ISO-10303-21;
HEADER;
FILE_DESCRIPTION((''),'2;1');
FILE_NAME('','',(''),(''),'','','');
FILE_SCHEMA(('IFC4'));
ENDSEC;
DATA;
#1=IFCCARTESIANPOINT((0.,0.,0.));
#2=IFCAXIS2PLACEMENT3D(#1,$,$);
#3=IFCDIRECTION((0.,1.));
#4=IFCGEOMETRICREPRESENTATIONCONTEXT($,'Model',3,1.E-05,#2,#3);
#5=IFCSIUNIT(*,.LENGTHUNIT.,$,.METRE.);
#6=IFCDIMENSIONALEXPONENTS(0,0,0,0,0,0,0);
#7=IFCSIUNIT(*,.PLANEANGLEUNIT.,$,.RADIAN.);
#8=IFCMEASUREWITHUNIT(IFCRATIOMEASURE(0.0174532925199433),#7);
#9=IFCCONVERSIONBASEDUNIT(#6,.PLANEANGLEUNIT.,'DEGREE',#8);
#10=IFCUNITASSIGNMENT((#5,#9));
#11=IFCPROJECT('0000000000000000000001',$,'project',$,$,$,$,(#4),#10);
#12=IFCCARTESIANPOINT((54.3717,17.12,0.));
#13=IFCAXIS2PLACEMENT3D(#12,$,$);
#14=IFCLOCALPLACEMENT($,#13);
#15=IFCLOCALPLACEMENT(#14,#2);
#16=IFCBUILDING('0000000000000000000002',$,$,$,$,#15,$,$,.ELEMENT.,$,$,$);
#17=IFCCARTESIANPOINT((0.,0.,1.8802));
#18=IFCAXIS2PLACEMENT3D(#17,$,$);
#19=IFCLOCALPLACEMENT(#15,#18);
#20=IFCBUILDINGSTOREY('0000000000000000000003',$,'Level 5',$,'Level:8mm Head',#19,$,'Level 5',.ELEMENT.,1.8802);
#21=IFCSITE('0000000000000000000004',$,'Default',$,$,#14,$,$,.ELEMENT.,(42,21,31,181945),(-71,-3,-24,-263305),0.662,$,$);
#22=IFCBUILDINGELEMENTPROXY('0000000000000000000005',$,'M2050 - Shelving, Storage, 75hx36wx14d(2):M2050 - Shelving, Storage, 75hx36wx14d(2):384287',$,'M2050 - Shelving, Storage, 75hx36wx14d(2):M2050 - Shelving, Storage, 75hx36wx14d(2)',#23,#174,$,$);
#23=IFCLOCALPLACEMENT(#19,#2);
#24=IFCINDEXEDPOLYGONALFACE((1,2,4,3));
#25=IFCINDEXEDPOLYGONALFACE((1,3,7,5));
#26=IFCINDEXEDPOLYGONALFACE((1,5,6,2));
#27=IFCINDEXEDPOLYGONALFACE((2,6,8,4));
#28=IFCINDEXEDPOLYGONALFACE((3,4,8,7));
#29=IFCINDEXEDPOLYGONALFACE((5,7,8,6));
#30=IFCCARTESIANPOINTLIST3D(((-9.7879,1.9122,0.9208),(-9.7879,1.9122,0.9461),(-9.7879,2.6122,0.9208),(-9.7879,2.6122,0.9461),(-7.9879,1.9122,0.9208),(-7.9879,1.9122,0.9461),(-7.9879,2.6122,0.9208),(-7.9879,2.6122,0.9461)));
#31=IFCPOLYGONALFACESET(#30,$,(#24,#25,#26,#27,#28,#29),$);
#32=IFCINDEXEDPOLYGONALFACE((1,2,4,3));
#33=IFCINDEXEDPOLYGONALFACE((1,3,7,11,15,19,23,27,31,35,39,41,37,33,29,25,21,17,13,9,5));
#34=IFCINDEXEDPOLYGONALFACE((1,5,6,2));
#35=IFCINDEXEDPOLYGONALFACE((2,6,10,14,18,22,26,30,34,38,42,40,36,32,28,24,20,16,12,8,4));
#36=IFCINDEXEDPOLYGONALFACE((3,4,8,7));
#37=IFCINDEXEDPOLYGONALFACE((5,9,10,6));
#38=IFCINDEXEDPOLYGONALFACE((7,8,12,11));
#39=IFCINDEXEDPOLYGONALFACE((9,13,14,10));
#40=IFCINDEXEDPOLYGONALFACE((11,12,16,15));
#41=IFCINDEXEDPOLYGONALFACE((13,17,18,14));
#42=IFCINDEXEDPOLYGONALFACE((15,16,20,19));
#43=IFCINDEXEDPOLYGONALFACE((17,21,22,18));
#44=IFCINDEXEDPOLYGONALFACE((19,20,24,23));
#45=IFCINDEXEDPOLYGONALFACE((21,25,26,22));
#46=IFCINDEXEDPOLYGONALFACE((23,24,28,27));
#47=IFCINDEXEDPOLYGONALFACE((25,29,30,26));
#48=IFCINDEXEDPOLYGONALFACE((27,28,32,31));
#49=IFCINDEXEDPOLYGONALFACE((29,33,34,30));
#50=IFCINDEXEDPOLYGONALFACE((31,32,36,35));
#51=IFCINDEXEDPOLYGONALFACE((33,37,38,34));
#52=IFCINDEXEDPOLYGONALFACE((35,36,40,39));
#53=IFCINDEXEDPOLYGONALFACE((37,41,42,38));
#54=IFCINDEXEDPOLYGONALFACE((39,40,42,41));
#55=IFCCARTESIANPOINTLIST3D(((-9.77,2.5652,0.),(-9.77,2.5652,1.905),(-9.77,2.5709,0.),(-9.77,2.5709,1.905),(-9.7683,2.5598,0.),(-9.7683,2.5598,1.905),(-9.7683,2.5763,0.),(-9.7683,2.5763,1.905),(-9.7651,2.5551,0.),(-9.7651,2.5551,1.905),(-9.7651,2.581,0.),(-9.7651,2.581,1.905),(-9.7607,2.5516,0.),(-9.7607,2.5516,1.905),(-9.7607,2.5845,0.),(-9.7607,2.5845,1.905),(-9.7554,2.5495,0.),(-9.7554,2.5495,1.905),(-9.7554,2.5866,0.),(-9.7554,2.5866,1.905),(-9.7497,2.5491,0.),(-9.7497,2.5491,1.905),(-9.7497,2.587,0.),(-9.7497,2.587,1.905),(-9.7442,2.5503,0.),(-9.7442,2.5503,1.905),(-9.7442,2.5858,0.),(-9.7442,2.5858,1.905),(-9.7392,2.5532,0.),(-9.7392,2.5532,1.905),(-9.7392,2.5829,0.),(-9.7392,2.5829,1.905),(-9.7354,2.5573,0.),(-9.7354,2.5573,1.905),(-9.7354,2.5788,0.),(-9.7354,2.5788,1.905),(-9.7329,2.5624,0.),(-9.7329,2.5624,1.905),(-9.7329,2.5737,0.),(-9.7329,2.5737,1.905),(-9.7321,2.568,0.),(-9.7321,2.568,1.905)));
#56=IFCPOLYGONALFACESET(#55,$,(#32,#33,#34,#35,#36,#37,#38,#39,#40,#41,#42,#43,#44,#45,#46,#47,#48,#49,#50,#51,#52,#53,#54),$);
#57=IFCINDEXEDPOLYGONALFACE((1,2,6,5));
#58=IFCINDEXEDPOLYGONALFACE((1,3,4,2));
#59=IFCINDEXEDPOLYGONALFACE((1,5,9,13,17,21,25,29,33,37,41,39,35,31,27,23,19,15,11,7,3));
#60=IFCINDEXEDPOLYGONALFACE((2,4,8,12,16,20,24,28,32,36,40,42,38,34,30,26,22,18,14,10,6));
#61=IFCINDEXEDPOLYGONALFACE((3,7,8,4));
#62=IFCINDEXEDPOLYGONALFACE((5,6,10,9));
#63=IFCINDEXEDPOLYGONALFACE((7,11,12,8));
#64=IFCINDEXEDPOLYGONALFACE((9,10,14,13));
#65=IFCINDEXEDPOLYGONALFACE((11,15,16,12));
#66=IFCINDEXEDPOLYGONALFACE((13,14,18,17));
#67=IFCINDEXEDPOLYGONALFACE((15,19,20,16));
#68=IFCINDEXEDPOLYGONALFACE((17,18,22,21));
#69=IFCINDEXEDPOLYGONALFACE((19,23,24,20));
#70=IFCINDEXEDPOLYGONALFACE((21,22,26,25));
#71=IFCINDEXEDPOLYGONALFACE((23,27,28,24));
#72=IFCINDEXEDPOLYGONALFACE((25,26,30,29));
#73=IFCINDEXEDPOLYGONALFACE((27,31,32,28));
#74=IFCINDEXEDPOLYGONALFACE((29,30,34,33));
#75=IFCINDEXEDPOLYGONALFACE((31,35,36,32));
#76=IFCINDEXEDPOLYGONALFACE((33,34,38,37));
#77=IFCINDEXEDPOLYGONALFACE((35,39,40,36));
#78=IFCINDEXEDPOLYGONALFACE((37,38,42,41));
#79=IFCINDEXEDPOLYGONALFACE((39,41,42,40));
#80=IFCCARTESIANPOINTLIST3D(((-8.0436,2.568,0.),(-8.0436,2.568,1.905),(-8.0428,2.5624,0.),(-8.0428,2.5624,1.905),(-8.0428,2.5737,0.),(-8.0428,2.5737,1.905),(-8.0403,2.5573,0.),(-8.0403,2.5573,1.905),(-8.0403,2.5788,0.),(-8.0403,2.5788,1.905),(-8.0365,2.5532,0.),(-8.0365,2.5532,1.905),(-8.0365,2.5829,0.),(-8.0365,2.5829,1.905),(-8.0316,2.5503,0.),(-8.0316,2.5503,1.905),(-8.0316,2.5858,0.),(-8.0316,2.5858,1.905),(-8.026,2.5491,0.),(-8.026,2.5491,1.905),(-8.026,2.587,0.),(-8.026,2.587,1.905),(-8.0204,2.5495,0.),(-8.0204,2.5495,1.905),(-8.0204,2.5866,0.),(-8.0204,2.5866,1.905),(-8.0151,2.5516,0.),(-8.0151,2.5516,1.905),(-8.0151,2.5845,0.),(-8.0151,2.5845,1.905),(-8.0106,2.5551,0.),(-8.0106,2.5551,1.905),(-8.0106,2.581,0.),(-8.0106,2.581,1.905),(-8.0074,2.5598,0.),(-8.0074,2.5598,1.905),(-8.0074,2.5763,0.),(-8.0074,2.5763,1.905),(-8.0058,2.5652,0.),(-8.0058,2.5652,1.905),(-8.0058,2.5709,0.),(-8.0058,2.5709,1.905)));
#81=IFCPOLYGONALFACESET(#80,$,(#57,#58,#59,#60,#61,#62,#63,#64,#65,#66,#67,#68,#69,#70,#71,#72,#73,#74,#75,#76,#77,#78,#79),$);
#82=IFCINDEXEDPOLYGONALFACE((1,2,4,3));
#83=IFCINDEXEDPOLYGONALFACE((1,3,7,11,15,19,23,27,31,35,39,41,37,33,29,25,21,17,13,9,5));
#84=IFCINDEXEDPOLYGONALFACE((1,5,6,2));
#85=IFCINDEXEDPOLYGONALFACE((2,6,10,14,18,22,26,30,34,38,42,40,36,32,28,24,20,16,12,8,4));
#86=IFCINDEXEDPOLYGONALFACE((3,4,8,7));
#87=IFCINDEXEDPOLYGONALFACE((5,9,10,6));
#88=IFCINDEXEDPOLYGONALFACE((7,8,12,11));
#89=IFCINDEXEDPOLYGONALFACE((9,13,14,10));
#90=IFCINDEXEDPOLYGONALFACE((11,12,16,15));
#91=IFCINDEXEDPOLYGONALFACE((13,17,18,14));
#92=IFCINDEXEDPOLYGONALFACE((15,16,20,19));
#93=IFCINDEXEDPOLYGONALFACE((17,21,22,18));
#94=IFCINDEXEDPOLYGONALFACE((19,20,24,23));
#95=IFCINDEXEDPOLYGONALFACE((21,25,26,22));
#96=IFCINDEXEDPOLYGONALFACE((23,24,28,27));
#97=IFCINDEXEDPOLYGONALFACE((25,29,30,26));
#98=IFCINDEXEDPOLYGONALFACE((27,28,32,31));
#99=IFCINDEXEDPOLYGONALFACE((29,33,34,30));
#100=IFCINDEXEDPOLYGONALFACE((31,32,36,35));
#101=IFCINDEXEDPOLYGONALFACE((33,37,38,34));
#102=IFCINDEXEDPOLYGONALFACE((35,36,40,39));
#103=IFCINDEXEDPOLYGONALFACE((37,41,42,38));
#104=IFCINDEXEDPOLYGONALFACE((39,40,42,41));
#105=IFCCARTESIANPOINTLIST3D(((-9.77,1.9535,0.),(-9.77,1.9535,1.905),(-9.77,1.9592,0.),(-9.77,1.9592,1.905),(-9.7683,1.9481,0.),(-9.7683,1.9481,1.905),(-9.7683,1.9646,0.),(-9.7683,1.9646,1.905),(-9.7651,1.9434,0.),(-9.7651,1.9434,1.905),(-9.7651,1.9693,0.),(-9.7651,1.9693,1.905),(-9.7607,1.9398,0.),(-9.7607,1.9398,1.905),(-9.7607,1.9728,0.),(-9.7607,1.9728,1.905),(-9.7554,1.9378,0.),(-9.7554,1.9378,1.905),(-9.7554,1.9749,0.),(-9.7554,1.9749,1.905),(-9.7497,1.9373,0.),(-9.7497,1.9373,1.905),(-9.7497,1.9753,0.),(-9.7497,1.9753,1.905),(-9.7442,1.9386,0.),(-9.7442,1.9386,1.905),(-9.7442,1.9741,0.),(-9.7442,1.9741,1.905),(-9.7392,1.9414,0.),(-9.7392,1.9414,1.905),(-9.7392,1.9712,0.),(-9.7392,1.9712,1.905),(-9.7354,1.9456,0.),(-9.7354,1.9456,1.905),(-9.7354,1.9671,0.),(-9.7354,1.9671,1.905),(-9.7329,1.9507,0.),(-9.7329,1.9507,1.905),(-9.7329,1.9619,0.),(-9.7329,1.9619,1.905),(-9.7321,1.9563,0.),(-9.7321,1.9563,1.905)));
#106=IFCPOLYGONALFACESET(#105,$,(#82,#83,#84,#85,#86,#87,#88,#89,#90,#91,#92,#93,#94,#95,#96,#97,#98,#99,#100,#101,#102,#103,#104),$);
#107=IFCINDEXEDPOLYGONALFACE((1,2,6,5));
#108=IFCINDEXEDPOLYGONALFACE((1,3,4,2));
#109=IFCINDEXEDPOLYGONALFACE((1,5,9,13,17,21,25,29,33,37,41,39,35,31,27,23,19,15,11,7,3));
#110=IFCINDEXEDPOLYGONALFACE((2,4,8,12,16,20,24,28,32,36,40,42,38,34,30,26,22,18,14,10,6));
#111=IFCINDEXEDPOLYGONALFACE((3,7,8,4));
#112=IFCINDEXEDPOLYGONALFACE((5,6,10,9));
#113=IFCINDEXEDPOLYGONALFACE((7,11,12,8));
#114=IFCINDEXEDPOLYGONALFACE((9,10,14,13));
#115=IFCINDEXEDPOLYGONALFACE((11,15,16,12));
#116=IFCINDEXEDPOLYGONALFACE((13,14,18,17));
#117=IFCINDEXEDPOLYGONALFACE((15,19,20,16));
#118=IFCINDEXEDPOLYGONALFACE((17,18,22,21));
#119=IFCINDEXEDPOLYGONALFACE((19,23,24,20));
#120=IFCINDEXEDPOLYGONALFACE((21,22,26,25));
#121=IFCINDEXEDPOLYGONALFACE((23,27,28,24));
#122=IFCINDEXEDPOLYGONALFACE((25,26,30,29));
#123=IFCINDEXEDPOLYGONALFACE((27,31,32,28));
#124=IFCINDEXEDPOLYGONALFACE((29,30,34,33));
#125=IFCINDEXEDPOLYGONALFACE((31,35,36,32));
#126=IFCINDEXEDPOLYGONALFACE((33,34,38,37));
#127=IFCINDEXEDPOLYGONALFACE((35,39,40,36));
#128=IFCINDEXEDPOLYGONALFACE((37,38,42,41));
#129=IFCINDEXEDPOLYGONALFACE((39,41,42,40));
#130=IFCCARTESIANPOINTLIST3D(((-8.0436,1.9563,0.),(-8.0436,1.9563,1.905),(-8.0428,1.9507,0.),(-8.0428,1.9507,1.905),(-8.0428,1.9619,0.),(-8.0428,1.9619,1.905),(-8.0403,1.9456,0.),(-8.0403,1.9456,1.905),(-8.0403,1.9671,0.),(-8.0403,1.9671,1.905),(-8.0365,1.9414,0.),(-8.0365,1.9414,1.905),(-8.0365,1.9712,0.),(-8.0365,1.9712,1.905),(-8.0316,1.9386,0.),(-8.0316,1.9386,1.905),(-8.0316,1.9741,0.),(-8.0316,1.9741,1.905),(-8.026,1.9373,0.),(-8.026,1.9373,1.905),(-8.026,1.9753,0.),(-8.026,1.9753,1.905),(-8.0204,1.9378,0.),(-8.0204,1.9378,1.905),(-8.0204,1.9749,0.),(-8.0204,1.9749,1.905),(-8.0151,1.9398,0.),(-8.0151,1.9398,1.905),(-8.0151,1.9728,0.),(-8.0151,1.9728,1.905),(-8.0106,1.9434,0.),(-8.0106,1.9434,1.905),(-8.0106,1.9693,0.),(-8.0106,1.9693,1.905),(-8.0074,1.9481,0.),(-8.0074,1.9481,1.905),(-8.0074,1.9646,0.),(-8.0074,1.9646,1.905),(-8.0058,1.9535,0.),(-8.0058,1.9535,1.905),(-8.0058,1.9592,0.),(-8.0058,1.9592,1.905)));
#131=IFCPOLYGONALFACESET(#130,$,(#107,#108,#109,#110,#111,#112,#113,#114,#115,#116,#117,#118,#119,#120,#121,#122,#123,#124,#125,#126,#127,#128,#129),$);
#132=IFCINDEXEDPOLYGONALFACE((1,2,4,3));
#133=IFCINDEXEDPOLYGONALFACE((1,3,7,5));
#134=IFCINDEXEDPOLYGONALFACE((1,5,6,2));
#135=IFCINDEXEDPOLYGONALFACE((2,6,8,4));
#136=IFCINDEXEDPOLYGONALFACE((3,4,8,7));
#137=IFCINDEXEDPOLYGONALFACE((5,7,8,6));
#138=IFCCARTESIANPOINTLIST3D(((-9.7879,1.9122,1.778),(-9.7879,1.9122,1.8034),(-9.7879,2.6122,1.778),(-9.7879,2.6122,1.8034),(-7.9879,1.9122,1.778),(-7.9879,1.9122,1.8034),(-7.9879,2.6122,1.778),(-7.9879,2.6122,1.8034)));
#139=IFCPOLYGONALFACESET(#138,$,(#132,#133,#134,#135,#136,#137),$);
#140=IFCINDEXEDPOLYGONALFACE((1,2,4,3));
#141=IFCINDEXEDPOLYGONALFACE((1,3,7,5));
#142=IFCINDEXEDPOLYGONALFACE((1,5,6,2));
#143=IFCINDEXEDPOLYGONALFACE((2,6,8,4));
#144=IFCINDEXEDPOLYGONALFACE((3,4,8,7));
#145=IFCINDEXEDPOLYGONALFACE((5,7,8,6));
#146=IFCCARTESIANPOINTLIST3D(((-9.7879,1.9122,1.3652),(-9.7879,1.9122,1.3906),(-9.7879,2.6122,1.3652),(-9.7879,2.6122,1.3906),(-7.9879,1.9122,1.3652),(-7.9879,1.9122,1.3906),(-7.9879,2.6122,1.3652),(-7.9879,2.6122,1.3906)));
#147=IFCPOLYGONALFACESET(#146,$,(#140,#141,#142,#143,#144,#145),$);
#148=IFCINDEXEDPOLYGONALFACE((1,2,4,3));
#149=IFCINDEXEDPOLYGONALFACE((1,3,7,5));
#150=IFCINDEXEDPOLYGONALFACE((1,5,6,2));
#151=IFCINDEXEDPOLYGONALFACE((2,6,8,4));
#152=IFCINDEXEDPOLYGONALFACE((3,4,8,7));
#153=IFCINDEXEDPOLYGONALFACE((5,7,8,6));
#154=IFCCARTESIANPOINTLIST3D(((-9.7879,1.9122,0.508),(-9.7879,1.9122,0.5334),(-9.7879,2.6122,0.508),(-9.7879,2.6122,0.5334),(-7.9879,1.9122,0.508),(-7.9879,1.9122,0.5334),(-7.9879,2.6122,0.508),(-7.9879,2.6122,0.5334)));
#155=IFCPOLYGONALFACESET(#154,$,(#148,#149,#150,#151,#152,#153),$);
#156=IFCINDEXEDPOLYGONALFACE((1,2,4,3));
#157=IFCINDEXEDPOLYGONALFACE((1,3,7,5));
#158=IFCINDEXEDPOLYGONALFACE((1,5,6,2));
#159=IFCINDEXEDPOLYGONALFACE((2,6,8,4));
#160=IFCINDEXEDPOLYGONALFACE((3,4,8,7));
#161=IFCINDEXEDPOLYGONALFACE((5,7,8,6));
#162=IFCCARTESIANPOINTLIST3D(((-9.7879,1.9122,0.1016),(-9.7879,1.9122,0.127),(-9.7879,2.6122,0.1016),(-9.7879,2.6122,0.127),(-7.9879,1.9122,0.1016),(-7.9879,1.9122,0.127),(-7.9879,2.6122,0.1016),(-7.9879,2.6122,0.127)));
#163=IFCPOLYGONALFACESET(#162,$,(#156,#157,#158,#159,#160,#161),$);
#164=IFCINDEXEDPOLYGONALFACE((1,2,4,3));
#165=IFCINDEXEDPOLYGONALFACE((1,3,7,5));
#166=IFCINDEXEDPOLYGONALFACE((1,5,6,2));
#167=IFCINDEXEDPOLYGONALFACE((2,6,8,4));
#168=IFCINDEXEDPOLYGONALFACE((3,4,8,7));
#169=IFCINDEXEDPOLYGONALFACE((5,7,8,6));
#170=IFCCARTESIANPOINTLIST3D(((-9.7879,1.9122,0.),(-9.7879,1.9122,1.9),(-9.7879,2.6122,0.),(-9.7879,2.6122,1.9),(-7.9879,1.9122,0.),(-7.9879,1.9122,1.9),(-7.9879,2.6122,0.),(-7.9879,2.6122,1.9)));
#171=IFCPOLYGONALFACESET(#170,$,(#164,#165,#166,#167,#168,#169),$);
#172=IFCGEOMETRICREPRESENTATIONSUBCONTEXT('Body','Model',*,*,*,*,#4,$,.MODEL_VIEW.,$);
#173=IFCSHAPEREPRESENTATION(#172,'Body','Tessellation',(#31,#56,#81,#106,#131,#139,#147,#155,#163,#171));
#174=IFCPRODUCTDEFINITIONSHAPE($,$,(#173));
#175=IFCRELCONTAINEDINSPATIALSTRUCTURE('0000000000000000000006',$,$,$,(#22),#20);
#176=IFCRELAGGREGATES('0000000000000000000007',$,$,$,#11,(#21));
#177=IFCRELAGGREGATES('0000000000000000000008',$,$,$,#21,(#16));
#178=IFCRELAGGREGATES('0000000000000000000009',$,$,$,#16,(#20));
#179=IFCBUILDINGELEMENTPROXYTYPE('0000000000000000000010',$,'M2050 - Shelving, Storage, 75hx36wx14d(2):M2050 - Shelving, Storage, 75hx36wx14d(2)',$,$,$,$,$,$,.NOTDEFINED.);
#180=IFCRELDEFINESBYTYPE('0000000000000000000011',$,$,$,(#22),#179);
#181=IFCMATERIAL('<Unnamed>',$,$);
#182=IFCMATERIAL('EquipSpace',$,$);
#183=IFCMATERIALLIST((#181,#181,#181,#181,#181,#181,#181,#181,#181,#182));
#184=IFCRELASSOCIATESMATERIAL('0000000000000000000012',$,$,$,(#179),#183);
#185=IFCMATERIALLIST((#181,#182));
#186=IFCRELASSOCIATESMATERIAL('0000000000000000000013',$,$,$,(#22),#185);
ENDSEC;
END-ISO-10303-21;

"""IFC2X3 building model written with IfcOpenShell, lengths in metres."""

from ifc_helpers import new_model, entity, si_unit, converted_unit, direction, frame, frame_2d, origin, origin_2d_with_axis, place, context, subcontext, project, spatial, rectangle, circle, extrude, source, transform, mapped, material, material_list, type_object, type_shapes, element, save


model = new_model("IFC2X3")

# Units and contexts
model_context = context("Model", 3, precision=1e-05, world=origin(), true_north=direction((0.0, 1.0)))
body_context = subcontext(model_context, "Body", "Model", "MODEL_VIEW")
ifc_project = project(units=[si_unit("LENGTHUNIT", "METRE"), converted_unit("PLANEANGLEUNIT", "DEGREE", entity("IfcRatioMeasure", 0.0174532925199433), si_unit("PLANEANGLEUNIT", "RADIAN"), dimensions=[0, 0, 0, 0, 0, 0, 0])], contexts=[model_context])

# Site, building, storey
site_placement = place(None, frame((54.3717, 17.12, 0.0)))
site = spatial("IfcSite", under=ifc_project, at=site_placement, Name="Default", CompositionType="ELEMENT", RefLatitude=(42, 21, 31, 181945), RefLongitude=(-71, -3, -24, -263305), RefElevation=0.662)
building_placement = place(site_placement, origin())
building = spatial("IfcBuilding", under=site, at=building_placement, CompositionType="ELEMENT")
storey_placement = place(building_placement, frame((0.0, 0.0, 1.8802)))
storey = spatial("IfcBuildingStorey", under=building, at=storey_placement, Name="Level 5", ObjectType="Level:8mm Head", LongName="Level 5", CompositionType="ELEMENT", Elevation=1.8802)

# Building element proxy
ifc_material_1 = material(Name="<Unnamed>")
ifc_material_2 = material(Name="EquipSpace")
ifc_material_list_1 = material_list([ifc_material_1, ifc_material_1, ifc_material_1, ifc_material_1, ifc_material_1, ifc_material_1, ifc_material_1, ifc_material_1, ifc_material_1, ifc_material_2])
building_element_proxy_type = type_object("IfcBuildingElementProxyType", Name="M2050 - Shelving, Storage, 75hx36wx14d(2):M2050 - Shelving, Storage, 75hx36wx14d(2)", PredefinedType="NOTDEFINED", material=ifc_material_list_1)
shared_shape = source(origin(), body_context, "Body", "SweptSolid", [
    extrude(rectangle(XDim=1.8, YDim=0.7, at=origin_2d_with_axis()), frame((0.0, 0.0, 0.9207), z_axis=(0.0, 0.0, 1.0), x_axis=(-1.0, 0.0, 0.0)), (0.0, 0.0, 1.0), 0.0254),
    extrude(circle(Radius=0.0191, at=origin_2d_with_axis()), frame((0.8633, -0.3059, 0.0), z_axis=(0.0, 0.0, 1.0), x_axis=(-1.0, 0.0, 0.0)), (0.0, 0.0, 1.0), 1.905),
    extrude(circle(Radius=0.0191, at=origin_2d_with_axis()), frame((-0.8633, -0.3059, 0.0)), (0.0, 0.0, 1.0), 1.905),
    extrude(circle(Radius=0.0191, at=origin_2d_with_axis()), frame((0.8633, 0.3059, 0.0), z_axis=(0.0, 0.0, 1.0), x_axis=(-1.0, 0.0, 0.0)), (0.0, 0.0, 1.0), 1.905),
    extrude(circle(Radius=0.0191, at=origin_2d_with_axis()), frame((-0.8633, 0.3059, 0.0)), (0.0, 0.0, 1.0), 1.905),
    extrude(rectangle(XDim=1.8, YDim=0.7, at=origin_2d_with_axis()), frame((0.0, 0.0, 1.778), z_axis=(0.0, 0.0, 1.0), x_axis=(-1.0, 0.0, 0.0)), (0.0, 0.0, 1.0), 0.0254),
    extrude(rectangle(XDim=1.8, YDim=0.7, at=origin_2d_with_axis()), frame((0.0, 0.0, 1.3653), z_axis=(0.0, 0.0, 1.0), x_axis=(-1.0, 0.0, 0.0)), (0.0, 0.0, 1.0), 0.0254),
    extrude(rectangle(XDim=1.8, YDim=0.7, at=origin_2d_with_axis()), frame((0.0, 0.0, 0.508), z_axis=(0.0, 0.0, 1.0), x_axis=(-1.0, 0.0, 0.0)), (0.0, 0.0, 1.0), 0.0254),
    extrude(rectangle(XDim=1.8, YDim=0.7, at=origin_2d_with_axis()), frame((0.0, 0.0, 0.1016), z_axis=(0.0, 0.0, 1.0), x_axis=(-1.0, 0.0, 0.0)), (0.0, 0.0, 1.0), 0.0254),
    extrude(rectangle(XDim=0.7, YDim=1.8, at=frame_2d((0.0, 0.18), x_axis=(1.0, 0.0))), frame((-0.18, 0.0, 0.0), z_axis=(0.0, 0.0, 1.0), x_axis=(0.0, -1.0, 0.0)), (0.0, 0.0, 1.0), 1.9),
])
type_shapes(building_element_proxy_type, [shared_shape])
ifc_material_list_2 = material_list([ifc_material_1, ifc_material_2])
proxy_1_placement = place(storey_placement, frame((-8.8879, 2.2622, 0.0), z_axis=(0.0, 0.0, 1.0), x_axis=(-1.0, 0.0, 0.0)))
element("IfcBuildingElementProxy", 1, at=proxy_1_placement, inside=storey, type_object=building_element_proxy_type, material=ifc_material_list_2, Name="M2050 - Shelving, Storage, 75hx36wx14d(2):M2050 - Shelving, Storage, 75hx36wx14d(2):384287", ObjectType="M2050 - Shelving, Storage, 75hx36wx14d(2):M2050 - Shelving, Storage, 75hx36wx14d(2)", context=body_context, shape_type="MappedRepresentation", body=[
    mapped(shared_shape, transform((0.0, 0.0, 0.0), scale=1.0)),
])

save(model, "model.ifc")
